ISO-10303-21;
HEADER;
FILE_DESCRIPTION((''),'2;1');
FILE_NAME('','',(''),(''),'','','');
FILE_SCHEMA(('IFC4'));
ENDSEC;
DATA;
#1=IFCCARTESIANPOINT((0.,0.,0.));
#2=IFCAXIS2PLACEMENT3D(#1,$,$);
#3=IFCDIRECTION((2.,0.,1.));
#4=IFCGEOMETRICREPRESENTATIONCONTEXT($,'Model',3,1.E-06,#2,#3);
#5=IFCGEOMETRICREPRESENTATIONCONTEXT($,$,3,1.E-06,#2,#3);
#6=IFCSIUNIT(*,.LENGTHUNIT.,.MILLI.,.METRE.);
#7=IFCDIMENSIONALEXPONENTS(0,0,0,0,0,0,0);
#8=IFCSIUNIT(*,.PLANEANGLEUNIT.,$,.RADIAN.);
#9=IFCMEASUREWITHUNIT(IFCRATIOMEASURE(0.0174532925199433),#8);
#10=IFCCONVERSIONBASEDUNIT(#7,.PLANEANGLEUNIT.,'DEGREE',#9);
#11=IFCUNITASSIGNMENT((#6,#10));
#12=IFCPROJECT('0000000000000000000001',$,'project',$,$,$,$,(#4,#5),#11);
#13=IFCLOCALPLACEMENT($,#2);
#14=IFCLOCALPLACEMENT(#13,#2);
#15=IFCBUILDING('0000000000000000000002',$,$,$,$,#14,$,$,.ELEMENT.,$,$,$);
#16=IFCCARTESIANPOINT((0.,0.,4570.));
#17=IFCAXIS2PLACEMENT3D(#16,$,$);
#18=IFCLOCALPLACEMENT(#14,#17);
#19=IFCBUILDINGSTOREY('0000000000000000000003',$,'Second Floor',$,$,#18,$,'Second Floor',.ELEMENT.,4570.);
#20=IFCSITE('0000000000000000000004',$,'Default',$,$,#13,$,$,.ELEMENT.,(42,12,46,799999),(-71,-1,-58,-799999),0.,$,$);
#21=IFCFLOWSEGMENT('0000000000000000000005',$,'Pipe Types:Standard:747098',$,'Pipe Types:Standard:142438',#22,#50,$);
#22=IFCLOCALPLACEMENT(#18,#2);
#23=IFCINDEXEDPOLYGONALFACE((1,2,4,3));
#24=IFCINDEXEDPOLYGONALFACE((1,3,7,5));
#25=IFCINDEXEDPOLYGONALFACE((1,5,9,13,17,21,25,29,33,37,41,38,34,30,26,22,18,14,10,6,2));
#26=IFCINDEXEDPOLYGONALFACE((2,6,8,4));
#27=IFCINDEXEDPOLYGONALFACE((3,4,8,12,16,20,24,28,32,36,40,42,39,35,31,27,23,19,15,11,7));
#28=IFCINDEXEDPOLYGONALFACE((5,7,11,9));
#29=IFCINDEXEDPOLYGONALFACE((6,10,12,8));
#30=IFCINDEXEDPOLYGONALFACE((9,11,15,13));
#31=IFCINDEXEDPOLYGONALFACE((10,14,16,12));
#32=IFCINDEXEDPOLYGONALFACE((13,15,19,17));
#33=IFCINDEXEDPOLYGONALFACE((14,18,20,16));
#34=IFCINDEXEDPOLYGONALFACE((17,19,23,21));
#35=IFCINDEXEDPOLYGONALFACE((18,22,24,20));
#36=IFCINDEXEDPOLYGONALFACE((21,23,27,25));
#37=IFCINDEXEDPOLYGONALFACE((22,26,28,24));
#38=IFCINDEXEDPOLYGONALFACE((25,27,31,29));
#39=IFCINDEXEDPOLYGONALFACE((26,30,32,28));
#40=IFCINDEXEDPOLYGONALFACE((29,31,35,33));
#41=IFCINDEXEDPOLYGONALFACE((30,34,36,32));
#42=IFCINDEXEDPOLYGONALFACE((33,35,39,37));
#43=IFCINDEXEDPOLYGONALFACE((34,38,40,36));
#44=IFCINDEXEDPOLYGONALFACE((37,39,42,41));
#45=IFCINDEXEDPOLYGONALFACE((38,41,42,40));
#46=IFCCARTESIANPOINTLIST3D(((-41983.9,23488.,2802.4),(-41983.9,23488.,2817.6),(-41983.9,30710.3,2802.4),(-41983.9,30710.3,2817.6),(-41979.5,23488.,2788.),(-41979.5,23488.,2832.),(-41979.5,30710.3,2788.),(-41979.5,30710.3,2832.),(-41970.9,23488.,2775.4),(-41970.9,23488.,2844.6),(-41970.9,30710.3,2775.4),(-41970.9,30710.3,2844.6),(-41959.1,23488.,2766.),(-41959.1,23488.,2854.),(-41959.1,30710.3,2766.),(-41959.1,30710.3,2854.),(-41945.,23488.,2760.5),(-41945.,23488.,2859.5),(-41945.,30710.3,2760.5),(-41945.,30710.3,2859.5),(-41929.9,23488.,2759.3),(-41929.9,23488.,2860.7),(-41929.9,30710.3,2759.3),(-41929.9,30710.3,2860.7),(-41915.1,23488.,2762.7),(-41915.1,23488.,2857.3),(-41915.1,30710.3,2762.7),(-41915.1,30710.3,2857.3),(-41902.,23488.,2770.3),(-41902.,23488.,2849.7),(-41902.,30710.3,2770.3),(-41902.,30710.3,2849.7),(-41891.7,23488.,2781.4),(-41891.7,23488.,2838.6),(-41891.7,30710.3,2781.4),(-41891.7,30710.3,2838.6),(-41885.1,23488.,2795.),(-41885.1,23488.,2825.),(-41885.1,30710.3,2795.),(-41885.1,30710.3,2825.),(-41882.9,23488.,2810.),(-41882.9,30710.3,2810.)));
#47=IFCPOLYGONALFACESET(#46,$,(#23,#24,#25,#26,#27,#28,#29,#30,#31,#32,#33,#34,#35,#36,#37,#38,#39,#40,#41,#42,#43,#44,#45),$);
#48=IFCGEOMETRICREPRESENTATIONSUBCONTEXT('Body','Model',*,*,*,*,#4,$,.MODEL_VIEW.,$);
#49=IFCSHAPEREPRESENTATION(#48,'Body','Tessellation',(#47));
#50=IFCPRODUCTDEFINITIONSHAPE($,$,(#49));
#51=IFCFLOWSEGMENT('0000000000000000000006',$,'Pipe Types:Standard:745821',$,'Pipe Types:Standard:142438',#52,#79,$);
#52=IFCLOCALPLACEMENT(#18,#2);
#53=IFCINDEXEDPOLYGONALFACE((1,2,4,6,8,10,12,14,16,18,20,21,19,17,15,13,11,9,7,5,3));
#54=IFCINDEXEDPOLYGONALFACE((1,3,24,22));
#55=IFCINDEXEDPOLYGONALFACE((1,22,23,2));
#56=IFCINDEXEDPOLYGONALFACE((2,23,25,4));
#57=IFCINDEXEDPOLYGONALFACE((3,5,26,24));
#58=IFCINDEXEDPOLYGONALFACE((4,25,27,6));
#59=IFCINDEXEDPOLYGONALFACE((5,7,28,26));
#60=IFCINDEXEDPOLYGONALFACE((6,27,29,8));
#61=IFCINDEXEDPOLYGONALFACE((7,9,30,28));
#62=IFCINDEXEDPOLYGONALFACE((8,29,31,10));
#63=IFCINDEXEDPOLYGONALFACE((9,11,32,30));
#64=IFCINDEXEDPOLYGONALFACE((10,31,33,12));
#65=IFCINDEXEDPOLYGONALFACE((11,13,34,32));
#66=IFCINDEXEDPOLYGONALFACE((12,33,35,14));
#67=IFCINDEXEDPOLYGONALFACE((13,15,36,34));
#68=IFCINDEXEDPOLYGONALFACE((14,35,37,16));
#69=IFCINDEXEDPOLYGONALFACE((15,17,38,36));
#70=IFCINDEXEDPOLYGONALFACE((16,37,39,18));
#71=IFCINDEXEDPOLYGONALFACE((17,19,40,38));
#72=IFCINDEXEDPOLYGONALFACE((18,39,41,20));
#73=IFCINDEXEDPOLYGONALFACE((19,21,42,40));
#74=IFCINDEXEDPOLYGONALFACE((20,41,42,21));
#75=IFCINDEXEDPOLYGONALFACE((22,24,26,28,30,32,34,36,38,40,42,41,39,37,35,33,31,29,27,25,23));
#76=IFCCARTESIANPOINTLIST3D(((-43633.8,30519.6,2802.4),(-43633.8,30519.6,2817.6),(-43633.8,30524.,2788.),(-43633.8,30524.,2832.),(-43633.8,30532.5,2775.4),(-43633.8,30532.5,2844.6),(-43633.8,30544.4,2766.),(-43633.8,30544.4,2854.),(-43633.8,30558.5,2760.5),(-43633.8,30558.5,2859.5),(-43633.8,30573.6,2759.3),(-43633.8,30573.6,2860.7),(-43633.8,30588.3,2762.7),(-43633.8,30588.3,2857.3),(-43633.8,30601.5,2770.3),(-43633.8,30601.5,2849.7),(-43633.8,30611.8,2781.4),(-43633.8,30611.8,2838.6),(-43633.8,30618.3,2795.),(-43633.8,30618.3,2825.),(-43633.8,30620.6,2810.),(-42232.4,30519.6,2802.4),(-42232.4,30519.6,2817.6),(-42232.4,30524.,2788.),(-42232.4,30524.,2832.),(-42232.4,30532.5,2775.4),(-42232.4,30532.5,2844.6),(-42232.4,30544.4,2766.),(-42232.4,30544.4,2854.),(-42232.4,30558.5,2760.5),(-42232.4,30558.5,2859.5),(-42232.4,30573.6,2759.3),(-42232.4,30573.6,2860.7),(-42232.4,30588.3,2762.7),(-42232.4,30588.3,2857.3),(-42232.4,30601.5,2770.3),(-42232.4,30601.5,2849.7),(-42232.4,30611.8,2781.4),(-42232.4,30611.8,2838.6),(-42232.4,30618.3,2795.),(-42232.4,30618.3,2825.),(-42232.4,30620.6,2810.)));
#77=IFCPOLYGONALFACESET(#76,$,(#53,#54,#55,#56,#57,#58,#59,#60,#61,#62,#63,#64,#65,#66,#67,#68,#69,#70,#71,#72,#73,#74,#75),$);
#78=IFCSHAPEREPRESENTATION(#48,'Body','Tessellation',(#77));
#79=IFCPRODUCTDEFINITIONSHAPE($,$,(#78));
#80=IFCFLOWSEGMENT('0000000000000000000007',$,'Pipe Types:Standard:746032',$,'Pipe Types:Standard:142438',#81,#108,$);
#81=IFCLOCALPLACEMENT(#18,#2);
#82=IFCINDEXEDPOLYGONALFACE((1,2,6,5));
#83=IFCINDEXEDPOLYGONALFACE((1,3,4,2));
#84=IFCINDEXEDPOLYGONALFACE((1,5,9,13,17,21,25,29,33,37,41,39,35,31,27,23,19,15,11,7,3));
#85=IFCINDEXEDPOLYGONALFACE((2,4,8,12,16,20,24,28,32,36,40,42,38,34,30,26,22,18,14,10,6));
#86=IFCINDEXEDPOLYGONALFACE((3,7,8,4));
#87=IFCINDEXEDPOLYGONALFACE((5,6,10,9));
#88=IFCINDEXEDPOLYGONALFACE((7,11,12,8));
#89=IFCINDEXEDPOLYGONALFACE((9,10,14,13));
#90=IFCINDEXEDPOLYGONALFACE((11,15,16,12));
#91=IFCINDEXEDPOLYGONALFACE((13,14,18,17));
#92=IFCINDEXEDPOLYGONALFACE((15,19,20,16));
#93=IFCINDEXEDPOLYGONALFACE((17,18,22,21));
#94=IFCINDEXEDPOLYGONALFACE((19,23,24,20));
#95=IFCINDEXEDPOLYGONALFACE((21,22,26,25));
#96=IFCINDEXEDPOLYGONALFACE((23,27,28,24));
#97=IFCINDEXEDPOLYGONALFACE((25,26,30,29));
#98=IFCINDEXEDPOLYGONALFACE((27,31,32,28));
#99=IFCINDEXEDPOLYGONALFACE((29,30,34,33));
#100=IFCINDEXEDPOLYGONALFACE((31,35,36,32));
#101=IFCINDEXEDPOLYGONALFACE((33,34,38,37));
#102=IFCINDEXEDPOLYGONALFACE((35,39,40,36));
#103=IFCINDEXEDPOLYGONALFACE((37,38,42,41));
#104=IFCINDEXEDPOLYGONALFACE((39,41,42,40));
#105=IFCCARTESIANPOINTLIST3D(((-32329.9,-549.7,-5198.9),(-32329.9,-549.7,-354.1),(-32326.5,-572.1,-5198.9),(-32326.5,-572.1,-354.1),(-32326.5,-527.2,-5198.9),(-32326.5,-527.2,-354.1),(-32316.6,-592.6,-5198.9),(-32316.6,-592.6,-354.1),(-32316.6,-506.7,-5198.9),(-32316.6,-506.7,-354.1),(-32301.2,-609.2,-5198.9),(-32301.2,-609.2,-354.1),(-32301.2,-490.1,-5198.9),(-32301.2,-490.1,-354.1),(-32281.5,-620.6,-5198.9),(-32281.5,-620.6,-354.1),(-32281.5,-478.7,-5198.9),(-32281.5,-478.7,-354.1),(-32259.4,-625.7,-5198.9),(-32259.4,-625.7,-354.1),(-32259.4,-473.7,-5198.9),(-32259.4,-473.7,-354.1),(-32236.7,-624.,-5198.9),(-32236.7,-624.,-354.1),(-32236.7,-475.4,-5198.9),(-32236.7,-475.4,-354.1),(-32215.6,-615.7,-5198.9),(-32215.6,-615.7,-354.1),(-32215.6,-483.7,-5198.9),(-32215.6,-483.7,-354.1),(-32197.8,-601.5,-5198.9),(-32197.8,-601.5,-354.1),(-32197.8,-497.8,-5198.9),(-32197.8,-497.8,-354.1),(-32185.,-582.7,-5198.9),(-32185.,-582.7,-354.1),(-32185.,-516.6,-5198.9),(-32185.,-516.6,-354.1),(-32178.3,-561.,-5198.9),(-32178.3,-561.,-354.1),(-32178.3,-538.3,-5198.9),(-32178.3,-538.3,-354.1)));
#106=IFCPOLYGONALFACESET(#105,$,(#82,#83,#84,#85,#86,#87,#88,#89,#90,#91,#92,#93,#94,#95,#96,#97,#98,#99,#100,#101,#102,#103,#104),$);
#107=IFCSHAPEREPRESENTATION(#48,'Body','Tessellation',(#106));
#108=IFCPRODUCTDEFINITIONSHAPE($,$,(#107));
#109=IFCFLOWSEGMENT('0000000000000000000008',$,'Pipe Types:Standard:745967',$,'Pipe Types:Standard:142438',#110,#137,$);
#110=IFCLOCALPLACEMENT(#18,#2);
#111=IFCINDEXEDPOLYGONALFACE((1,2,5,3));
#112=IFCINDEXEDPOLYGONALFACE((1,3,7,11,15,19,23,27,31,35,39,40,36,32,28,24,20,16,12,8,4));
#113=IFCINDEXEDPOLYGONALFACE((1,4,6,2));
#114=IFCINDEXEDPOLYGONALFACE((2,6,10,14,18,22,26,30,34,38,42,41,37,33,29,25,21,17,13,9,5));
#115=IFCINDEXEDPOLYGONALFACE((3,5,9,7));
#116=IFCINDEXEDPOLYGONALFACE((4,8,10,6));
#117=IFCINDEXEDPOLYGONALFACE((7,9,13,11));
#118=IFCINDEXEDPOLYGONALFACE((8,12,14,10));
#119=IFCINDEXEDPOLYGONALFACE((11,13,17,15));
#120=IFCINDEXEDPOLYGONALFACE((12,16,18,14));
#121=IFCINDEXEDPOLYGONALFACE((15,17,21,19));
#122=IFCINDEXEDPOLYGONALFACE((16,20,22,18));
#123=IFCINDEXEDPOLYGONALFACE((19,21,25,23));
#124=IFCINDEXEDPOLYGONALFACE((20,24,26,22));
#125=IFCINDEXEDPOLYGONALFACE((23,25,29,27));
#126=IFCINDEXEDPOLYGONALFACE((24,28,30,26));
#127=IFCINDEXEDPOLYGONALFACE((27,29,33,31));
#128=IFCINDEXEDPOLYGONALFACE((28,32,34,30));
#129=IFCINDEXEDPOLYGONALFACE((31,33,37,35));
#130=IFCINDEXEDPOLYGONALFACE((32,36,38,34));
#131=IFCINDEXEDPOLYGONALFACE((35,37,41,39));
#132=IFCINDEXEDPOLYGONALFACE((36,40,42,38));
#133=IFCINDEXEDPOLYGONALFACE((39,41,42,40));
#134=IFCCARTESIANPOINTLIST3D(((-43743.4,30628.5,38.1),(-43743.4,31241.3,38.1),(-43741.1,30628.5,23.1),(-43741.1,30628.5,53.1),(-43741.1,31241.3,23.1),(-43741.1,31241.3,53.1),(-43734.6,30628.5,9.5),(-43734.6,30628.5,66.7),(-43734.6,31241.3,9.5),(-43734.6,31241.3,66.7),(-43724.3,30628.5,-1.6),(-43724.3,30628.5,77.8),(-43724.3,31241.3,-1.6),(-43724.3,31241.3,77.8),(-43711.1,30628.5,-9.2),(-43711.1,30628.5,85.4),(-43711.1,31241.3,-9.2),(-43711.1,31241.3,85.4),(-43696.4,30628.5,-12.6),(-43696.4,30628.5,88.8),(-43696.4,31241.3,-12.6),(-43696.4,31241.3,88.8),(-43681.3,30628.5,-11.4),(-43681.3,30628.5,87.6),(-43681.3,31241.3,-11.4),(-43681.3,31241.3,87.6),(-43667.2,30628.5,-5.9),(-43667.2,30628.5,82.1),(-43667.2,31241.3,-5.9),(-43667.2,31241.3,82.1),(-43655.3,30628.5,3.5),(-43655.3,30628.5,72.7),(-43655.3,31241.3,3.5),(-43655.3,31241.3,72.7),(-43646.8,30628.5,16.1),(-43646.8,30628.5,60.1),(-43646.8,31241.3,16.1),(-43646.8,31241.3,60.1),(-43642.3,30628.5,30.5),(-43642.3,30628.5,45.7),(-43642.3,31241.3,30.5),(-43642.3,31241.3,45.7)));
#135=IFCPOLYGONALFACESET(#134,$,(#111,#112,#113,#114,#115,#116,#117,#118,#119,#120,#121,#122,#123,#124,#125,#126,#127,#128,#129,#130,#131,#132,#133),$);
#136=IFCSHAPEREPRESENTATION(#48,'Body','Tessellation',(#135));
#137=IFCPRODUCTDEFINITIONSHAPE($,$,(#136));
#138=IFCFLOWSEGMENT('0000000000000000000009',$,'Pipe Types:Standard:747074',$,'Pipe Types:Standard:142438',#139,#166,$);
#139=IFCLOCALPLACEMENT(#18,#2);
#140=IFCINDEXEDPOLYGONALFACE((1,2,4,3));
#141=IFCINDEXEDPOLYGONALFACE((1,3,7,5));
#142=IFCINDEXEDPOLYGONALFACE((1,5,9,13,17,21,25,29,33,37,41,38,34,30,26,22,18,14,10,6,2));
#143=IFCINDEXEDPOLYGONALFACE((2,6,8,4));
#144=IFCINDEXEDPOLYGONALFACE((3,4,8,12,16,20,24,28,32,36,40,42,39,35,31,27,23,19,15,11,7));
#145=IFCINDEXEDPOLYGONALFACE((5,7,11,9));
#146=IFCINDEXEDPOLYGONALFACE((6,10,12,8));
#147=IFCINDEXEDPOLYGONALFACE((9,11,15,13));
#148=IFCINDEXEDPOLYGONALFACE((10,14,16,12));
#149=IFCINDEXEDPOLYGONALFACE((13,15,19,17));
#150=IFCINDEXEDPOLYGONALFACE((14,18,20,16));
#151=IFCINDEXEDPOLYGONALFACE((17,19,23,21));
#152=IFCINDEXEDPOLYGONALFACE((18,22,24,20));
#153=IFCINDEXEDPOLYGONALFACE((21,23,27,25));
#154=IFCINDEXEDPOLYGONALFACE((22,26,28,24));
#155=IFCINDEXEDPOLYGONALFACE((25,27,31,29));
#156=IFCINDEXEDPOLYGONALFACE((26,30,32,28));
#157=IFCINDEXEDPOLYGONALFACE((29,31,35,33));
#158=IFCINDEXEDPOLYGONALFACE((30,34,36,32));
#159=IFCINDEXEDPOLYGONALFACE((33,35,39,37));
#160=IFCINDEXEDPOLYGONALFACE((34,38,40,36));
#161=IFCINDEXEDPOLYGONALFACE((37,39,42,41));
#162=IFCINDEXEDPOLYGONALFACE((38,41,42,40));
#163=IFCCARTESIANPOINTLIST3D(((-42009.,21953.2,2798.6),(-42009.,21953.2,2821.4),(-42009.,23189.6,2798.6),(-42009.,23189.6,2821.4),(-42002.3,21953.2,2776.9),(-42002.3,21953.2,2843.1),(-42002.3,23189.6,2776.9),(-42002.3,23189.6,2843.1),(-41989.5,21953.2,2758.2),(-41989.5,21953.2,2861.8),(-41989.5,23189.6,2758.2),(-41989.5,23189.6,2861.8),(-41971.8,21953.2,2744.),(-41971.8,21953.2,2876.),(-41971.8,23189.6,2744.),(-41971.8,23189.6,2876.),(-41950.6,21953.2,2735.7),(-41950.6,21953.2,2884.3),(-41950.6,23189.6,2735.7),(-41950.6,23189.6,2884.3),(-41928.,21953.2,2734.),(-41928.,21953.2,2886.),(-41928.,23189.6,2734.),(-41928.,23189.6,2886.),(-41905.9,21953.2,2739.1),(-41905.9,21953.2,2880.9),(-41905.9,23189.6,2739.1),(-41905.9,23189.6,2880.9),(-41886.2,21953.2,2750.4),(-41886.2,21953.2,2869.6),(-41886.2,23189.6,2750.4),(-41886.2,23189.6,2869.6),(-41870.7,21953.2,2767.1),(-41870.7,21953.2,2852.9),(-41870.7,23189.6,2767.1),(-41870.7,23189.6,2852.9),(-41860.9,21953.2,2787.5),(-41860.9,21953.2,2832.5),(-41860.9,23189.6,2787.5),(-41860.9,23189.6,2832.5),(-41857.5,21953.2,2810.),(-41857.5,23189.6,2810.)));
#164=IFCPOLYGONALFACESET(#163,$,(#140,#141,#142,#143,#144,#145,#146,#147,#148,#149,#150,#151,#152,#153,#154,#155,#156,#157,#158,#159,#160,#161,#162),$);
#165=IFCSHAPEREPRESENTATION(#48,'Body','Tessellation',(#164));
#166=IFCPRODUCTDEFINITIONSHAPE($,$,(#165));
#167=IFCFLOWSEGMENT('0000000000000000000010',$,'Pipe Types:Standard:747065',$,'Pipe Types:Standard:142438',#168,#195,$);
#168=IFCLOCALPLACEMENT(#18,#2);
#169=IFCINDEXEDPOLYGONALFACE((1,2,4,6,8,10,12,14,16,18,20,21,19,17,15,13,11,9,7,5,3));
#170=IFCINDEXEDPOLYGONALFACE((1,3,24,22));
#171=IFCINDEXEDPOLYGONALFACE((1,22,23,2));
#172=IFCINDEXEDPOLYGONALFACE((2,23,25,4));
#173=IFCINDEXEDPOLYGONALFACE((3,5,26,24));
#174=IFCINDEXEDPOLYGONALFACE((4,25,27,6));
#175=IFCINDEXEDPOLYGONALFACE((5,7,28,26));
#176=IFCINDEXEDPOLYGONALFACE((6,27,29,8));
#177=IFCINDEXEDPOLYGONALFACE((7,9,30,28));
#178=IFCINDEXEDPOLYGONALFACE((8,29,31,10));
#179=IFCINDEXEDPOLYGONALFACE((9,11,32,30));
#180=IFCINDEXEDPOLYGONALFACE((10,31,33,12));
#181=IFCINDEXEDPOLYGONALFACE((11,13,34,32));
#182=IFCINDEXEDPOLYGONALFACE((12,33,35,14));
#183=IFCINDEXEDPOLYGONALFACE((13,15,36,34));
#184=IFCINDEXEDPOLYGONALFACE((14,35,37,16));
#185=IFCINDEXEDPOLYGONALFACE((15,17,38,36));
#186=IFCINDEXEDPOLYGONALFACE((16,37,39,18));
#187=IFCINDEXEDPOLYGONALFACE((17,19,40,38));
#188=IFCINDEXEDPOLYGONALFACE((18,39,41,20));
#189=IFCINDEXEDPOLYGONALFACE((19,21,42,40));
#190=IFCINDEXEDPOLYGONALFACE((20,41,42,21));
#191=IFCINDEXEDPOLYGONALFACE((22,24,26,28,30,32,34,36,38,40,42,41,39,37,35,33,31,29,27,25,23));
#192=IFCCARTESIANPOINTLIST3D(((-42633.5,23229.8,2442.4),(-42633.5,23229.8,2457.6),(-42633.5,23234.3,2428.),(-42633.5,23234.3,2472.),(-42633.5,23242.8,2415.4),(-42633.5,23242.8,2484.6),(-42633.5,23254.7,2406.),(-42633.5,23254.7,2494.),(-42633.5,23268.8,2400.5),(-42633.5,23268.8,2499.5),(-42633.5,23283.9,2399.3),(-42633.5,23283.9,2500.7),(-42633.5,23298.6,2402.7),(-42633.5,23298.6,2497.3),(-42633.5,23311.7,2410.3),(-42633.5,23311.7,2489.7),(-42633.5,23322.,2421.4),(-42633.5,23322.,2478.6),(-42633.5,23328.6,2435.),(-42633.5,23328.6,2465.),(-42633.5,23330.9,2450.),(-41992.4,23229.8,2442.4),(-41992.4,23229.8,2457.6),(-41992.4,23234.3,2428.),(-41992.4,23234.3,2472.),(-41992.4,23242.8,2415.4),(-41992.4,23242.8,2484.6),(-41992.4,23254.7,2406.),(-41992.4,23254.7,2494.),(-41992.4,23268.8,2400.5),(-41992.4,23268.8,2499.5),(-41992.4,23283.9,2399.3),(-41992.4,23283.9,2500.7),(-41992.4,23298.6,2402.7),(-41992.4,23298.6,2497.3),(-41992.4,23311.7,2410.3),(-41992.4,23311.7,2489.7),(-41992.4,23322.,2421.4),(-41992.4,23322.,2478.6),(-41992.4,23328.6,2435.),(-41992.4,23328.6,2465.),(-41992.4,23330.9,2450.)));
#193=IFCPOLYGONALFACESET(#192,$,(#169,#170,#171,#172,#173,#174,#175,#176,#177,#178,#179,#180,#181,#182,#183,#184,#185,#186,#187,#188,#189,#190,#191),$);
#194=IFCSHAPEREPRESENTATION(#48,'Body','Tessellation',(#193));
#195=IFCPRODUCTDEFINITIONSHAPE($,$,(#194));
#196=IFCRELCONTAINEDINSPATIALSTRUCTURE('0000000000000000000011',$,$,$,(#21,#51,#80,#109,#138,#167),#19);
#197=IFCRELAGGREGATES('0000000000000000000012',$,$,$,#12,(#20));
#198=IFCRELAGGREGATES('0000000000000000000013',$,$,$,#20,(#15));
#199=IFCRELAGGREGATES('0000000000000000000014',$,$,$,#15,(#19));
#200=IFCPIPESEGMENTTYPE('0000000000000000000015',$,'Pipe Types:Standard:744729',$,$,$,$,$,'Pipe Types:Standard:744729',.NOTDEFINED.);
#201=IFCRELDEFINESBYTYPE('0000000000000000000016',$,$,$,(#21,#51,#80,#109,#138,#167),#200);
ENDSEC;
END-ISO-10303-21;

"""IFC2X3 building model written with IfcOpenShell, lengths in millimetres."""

from ifc_helpers import new_model, entity, si_unit, converted_unit, direction, frame, frame_2d, origin, origin_2d_with_axis, place, context, subcontext, project, spatial, circle, extrude, type_object, element, save


model = new_model("IFC2X3")

# Units and contexts
model_context = context("Model", 3, precision=1e-06, world=origin(), true_north=direction((2.0, 0.0, 1.0)))
context_of_model = context(None, 3, precision=1e-06, world=origin(), true_north=direction((2.0, 0.0, 1.0)))
body_context = subcontext(model_context, "Body", "Model", "MODEL_VIEW")
ifc_project = project(units=[si_unit("LENGTHUNIT", "METRE", prefix="MILLI"), converted_unit("PLANEANGLEUNIT", "DEGREE", entity("IfcRatioMeasure", 0.0174532925199433), si_unit("PLANEANGLEUNIT", "RADIAN"), dimensions=[0, 0, 0, 0, 0, 0, 0])], contexts=[model_context, context_of_model])

# Site, building, storey
site_placement = place(None, origin())
site = spatial("IfcSite", under=ifc_project, at=site_placement, Name="Default", CompositionType="ELEMENT", RefLatitude=(42, 12, 46, 799999), RefLongitude=(-71, -1, -58, -799999), RefElevation=0.0)
building_placement = place(site_placement, origin())
building = spatial("IfcBuilding", under=site, at=building_placement, CompositionType="ELEMENT")
storey_placement = place(building_placement, frame((0.0, 0.0, 4570.0)))
storey = spatial("IfcBuildingStorey", under=building, at=storey_placement, Name="Second Floor", LongName="Second Floor", CompositionType="ELEMENT", Elevation=4570.0)

# Flow segments
pipe_segment_type = type_object("IfcPipeSegmentType", Name="Pipe Types:Standard:744729", ElementType="Pipe Types:Standard:744729", PredefinedType="NOTDEFINED")
flow_segment_1_placement = place(storey_placement, origin())
element("IfcFlowSegment", 1, at=flow_segment_1_placement, inside=storey, type_object=pipe_segment_type, Name="Pipe Types:Standard:747098", ObjectType="Pipe Types:Standard:142438", context=body_context, shape_type="SweptSolid", body=[
    extrude(circle(Radius=50.8, at=origin_2d_with_axis()), frame((-41933.7, 23488.0, 2810.0), z_axis=(0.0, 1.0, 0.0), x_axis=(1.0, 0.0, 0.0)), (0.0, 0.0, 1.0), 7222.4),
])
flow_segment_2_placement = place(storey_placement, origin())
element("IfcFlowSegment", 2, at=flow_segment_2_placement, inside=storey, type_object=pipe_segment_type, Name="Pipe Types:Standard:745821", ObjectType="Pipe Types:Standard:142438", context=body_context, shape_type="SweptSolid", body=[
    extrude(circle(Radius=50.8, at=frame_2d((0.0, 0.0), x_axis=(1.0, 0.0))), frame((-43633.8, 30569.8, 2810.0), z_axis=(1.0, 0.0, 0.0), x_axis=(0.0, 1.0, 0.0)), (0.0, 0.0, 1.0), 1401.4),
])
flow_segment_3_placement = place(storey_placement, origin())
element("IfcFlowSegment", 3, at=flow_segment_3_placement, inside=storey, type_object=pipe_segment_type, Name="Pipe Types:Standard:746032", ObjectType="Pipe Types:Standard:142438", context=body_context, shape_type="SweptSolid", body=[
    extrude(circle(Radius=76.2, at=origin_2d_with_axis()), frame((-32253.7, -549.7, -5198.9), z_axis=(0.0, 0.0, 1.0), x_axis=(-1.0, 0.0, 0.0)), (0.0, 0.0, 1.0), 4844.7),
])
flow_segment_4_placement = place(storey_placement, origin())
element("IfcFlowSegment", 4, at=flow_segment_4_placement, inside=storey, type_object=pipe_segment_type, Name="Pipe Types:Standard:745967", ObjectType="Pipe Types:Standard:142438", context=body_context, shape_type="SweptSolid", body=[
    extrude(circle(Radius=50.8, at=origin_2d_with_axis()), frame((-43692.6, 30628.5, 38.1), z_axis=(0.0, 1.0, 0.0), x_axis=(-1.0, 0.0, 0.0)), (0.0, 0.0, 1.0), 612.8),
])
flow_segment_5_placement = place(storey_placement, origin())
element("IfcFlowSegment", 5, at=flow_segment_5_placement, inside=storey, type_object=pipe_segment_type, Name="Pipe Types:Standard:747074", ObjectType="Pipe Types:Standard:142438", context=body_context, shape_type="SweptSolid", body=[
    extrude(circle(Radius=76.2, at=origin_2d_with_axis()), frame((-41933.7, 21953.2, 2810.0), z_axis=(0.0, 1.0, 0.0), x_axis=(1.0, 0.0, 0.0)), (0.0, 0.0, 1.0), 1236.4),
])
flow_segment_6_placement = place(storey_placement, origin())
element("IfcFlowSegment", 6, at=flow_segment_6_placement, inside=storey, type_object=pipe_segment_type, Name="Pipe Types:Standard:747065", ObjectType="Pipe Types:Standard:142438", context=body_context, shape_type="SweptSolid", body=[
    extrude(circle(Radius=50.8, at=origin_2d_with_axis()), frame((-42633.5, 23280.1, 2450.0), z_axis=(1.0, 0.0, 0.0), x_axis=(0.0, 1.0, 0.0)), (0.0, 0.0, 1.0), 641.1),
])

save(model, "model.ifc")
